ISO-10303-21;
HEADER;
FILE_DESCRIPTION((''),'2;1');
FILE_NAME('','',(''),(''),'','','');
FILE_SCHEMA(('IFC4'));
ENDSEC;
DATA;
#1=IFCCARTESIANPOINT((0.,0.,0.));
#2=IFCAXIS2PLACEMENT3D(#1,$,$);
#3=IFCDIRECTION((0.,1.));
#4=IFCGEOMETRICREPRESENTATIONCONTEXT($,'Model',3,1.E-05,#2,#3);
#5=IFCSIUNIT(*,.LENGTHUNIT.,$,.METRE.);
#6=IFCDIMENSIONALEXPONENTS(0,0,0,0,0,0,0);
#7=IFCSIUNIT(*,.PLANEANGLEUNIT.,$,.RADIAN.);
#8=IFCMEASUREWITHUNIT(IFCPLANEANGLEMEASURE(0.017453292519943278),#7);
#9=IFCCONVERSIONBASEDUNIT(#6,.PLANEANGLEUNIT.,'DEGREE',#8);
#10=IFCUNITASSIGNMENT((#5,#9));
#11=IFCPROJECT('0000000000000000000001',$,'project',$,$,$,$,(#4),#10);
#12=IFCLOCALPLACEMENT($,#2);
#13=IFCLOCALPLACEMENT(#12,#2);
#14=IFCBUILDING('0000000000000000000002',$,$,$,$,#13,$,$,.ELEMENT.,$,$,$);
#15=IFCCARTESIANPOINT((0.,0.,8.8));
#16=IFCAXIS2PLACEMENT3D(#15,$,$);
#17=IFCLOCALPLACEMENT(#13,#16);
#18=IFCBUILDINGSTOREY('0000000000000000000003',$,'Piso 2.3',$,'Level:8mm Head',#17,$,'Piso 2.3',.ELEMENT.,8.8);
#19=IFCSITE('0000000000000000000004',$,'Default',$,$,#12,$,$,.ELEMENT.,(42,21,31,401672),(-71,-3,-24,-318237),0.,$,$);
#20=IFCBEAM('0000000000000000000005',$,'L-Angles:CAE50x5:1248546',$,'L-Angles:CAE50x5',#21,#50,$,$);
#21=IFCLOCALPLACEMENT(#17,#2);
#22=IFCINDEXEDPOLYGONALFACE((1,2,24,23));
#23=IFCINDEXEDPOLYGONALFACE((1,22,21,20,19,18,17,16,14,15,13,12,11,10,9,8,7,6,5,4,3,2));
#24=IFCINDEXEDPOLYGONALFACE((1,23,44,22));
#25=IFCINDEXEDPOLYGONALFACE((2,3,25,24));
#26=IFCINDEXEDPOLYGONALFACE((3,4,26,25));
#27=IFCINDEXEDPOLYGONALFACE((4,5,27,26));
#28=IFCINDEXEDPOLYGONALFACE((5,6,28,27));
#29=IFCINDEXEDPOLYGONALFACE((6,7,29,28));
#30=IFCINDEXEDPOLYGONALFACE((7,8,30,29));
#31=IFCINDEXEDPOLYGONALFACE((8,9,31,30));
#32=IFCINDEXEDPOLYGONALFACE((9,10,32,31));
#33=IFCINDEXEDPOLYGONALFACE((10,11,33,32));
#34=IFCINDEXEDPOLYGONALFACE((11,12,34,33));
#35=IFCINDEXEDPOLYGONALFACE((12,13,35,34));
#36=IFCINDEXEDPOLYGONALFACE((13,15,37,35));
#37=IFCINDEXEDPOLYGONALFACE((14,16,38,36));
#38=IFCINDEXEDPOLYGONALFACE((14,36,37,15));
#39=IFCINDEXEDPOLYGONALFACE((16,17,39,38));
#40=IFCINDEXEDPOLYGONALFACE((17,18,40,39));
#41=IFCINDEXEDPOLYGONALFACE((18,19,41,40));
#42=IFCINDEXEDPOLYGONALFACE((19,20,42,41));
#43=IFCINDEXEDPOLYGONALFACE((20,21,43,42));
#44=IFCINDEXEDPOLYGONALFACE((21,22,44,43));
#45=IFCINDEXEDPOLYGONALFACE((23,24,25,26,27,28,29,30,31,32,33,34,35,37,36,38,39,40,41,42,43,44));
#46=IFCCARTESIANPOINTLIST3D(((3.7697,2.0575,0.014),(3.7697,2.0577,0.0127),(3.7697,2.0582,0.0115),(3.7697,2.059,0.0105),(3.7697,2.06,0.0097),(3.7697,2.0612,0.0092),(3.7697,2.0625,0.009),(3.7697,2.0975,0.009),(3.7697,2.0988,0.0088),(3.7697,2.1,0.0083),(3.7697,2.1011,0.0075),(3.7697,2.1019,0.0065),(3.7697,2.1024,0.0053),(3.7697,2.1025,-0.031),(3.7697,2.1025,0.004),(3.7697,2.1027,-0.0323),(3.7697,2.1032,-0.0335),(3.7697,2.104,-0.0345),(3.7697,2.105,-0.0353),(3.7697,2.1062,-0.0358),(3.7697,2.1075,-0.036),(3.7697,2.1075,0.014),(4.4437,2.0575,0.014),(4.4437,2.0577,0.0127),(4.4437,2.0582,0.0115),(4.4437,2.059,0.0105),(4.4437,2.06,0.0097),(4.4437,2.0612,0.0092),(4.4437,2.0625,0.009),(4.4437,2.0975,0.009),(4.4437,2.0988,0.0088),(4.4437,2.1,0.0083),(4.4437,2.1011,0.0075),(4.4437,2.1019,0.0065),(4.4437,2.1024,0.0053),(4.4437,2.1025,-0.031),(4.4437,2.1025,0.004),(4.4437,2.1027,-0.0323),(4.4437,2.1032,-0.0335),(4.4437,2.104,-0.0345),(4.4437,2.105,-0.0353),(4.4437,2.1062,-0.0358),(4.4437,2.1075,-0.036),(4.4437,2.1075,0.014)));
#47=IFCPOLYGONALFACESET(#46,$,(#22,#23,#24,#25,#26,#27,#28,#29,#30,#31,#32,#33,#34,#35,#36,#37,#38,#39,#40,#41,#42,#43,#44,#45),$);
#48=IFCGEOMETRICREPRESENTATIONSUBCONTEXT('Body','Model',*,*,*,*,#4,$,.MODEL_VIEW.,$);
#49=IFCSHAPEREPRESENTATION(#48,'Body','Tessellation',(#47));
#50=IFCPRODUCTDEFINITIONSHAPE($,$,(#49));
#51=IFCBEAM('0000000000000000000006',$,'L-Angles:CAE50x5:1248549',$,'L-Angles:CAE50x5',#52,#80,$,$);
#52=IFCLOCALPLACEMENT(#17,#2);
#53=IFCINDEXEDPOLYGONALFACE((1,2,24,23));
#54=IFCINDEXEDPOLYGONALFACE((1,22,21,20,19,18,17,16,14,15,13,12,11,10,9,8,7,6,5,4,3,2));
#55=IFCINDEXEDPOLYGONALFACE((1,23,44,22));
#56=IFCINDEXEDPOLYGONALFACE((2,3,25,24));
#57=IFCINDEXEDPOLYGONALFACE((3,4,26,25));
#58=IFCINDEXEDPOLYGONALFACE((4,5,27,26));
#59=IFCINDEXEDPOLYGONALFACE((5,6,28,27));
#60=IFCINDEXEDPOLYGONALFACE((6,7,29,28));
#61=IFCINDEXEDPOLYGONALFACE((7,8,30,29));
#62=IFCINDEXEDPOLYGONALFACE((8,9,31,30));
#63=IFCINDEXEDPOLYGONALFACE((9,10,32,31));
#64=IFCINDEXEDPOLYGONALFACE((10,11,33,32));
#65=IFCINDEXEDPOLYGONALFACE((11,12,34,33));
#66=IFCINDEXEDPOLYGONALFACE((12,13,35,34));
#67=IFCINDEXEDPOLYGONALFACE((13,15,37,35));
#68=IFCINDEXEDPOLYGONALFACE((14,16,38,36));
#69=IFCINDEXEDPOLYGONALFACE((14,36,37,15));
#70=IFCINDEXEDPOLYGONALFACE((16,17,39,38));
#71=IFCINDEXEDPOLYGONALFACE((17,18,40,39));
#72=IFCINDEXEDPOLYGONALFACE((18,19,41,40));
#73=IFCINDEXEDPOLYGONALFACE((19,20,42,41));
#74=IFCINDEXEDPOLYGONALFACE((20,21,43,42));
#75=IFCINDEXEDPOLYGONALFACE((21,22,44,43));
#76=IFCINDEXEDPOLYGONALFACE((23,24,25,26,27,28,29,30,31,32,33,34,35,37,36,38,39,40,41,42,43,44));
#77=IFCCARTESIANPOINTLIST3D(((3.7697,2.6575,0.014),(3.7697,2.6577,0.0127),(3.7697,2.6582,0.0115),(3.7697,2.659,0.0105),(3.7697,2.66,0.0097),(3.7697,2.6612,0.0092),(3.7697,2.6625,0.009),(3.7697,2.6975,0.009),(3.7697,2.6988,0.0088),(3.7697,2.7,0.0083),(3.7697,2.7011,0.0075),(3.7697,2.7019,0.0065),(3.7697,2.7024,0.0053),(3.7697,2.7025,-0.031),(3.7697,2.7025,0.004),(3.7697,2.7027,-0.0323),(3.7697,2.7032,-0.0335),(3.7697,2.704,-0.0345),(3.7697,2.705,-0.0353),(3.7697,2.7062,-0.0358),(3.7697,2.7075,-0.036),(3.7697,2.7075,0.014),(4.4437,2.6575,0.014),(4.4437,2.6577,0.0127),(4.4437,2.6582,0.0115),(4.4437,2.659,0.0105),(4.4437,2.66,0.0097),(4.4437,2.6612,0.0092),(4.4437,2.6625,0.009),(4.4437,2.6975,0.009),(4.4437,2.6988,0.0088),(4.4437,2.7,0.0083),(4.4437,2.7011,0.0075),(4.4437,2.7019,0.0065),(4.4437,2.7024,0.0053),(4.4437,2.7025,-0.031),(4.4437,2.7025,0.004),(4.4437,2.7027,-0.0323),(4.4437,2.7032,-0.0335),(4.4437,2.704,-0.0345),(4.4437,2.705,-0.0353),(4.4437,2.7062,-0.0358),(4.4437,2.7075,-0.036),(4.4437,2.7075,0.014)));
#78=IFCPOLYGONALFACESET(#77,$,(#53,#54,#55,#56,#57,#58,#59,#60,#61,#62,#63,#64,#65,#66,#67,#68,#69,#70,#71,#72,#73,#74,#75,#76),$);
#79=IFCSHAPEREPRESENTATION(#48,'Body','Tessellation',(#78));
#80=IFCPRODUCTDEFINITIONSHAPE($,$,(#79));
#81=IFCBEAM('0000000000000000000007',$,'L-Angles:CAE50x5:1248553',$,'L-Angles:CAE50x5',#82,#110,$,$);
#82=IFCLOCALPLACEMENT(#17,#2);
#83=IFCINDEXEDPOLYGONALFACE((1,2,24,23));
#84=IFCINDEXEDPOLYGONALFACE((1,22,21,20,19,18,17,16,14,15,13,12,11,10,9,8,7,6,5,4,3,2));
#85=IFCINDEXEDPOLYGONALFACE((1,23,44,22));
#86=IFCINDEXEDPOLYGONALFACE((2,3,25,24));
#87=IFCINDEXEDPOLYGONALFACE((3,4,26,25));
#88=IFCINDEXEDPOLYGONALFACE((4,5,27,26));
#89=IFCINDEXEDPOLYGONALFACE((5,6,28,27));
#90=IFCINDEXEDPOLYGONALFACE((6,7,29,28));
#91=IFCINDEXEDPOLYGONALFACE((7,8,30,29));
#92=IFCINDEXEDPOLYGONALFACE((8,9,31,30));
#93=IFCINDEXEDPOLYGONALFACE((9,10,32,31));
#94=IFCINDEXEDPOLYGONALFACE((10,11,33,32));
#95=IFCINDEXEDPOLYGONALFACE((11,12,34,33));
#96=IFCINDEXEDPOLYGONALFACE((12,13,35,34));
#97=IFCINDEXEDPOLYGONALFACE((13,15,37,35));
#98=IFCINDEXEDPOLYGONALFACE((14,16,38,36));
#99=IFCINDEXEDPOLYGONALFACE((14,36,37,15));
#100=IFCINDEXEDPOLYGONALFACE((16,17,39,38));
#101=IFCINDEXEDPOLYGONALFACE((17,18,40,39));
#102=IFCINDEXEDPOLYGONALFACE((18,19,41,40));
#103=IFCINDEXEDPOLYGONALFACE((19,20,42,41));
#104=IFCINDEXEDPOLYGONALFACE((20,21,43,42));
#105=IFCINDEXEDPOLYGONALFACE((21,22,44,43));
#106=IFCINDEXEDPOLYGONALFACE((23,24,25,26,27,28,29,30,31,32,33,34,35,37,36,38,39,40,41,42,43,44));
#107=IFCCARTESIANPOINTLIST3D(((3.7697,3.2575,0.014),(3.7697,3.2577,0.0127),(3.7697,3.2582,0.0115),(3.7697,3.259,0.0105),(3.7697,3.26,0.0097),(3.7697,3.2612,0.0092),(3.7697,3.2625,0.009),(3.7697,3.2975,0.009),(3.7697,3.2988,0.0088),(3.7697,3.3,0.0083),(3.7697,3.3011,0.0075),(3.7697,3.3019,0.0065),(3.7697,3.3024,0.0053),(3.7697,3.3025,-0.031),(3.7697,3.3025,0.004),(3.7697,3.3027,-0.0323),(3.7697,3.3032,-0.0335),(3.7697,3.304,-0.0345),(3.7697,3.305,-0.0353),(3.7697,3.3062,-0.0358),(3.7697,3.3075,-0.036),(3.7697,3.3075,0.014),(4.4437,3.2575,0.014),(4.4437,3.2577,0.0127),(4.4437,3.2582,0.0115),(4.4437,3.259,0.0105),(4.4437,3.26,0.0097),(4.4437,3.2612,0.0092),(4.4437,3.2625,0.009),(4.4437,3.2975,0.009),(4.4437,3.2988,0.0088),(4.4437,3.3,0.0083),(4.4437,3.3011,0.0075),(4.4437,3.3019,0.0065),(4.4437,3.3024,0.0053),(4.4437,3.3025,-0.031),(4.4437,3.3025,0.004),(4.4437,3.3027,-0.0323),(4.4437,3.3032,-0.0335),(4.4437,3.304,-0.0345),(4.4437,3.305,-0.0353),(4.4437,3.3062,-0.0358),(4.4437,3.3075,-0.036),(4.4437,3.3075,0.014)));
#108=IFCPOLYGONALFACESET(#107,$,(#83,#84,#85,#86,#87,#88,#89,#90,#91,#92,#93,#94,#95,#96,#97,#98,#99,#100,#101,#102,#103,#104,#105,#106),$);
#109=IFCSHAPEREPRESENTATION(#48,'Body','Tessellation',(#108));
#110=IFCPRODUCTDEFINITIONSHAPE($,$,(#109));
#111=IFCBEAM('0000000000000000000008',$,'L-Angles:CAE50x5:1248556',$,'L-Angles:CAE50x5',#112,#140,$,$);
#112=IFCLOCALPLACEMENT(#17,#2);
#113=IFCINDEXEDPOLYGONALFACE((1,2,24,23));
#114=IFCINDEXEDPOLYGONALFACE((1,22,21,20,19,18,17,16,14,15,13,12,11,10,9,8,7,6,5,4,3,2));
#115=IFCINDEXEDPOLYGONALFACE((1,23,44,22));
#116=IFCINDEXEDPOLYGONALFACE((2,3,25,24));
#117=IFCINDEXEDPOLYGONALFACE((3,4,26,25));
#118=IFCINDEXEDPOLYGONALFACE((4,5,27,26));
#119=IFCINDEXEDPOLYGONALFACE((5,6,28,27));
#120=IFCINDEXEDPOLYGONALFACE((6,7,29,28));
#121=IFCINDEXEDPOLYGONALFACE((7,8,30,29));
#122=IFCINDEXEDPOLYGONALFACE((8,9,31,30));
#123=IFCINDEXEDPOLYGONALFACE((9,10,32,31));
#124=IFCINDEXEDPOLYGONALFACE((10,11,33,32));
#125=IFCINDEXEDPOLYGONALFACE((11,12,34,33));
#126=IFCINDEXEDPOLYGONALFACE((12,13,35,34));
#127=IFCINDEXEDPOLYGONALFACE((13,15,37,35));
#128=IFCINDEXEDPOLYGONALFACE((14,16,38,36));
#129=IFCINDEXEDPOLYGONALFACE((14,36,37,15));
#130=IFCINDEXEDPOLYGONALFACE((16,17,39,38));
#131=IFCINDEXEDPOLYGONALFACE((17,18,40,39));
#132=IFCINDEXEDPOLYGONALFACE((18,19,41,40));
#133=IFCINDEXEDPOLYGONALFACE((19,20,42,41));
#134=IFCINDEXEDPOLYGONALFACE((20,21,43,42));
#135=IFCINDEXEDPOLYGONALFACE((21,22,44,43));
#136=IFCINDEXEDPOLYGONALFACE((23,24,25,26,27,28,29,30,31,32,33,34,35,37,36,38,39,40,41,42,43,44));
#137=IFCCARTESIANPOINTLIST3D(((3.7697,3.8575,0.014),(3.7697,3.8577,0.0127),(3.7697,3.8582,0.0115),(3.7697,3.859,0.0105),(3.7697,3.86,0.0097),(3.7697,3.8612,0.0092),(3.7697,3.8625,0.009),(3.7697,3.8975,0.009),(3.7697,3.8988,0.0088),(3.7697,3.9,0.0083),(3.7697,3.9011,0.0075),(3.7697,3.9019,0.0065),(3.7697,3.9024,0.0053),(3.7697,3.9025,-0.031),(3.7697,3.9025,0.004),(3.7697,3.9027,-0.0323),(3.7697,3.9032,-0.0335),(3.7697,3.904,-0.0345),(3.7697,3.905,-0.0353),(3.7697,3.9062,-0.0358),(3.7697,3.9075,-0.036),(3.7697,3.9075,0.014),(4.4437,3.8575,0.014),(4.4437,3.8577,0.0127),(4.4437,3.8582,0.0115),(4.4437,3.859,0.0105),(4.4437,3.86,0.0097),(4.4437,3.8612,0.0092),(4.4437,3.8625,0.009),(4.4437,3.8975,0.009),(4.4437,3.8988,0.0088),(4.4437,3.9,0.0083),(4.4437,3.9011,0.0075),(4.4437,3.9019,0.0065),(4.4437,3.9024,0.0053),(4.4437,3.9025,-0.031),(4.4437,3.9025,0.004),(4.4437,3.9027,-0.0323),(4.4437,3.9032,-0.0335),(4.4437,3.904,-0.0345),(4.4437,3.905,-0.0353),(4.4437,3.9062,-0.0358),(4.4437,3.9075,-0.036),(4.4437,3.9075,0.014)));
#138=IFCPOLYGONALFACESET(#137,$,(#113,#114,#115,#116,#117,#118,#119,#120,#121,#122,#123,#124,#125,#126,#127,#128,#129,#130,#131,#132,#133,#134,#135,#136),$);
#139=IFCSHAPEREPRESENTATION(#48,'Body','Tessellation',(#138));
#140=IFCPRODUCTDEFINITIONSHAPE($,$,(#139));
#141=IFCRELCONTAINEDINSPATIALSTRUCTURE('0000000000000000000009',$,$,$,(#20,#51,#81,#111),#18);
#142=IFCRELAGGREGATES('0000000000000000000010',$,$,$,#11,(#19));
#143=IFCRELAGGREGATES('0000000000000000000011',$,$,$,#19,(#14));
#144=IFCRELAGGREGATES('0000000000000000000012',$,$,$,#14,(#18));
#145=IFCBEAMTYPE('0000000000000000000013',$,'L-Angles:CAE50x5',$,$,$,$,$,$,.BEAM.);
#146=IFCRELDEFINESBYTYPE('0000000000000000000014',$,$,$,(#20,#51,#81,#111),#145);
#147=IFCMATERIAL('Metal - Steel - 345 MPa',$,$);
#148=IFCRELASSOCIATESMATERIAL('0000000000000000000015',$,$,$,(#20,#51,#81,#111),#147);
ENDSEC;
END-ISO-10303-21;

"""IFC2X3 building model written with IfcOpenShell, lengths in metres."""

from ifc_helpers import new_model, entity, si_unit, converted_unit, direction, frame, frame_2d, origin, place, context, subcontext, project, spatial, polyline, circle_curve, parameter, trimmed, segment, composite_curve, outline, extrude, material, type_object, element, save


model = new_model("IFC2X3")

# Units and contexts
model_context = context("Model", 3, precision=1e-05, world=origin(), true_north=direction((0.0, 1.0)))
body_context = subcontext(model_context, "Body", "Model", "MODEL_VIEW")
ifc_project = project(units=[si_unit("LENGTHUNIT", "METRE"), converted_unit("PLANEANGLEUNIT", "DEGREE", entity("IfcPlaneAngleMeasure", 0.017453292519943278), si_unit("PLANEANGLEUNIT", "RADIAN"), dimensions=[0, 0, 0, 0, 0, 0, 0])], contexts=[model_context])

# Site, building, storey
site_placement = place(None, origin())
site = spatial("IfcSite", under=ifc_project, at=site_placement, Name="Default", CompositionType="ELEMENT", RefLatitude=(42, 21, 31, 401672), RefLongitude=(-71, -3, -24, -318237), RefElevation=0.0)
building_placement = place(site_placement, origin())
building = spatial("IfcBuilding", under=site, at=building_placement, CompositionType="ELEMENT")
storey_placement = place(building_placement, frame((0.0, 0.0, 8.8)))
storey = spatial("IfcBuildingStorey", under=building, at=storey_placement, Name="Piso 2.3", ObjectType="Level:8mm Head", LongName="Piso 2.3", CompositionType="ELEMENT", Elevation=8.8)

# Beams
ifc_material_1 = material(Name="Metal - Steel - 345 MPa")
beam_type_1 = type_object("IfcBeamType", Name="L-Angles:CAE50x5", PredefinedType="BEAM")
beam_1_placement = place(storey_placement, frame((3.7067, 2.0935, 0.0)))
element("IfcBeam", 1, at=beam_1_placement, inside=storey, type_object=beam_type_1, material=ifc_material_1, Name="L-Angles:CAE50x5:1248546", ObjectType="L-Angles:CAE50x5", context=body_context, shape_type="SweptSolid", body=[
    extrude(outline(composite_curve([segment(polyline([(-0.0336, -0.0164), (0.0164, -0.0164)]), True, "CONTINUOUS"), segment(polyline([(0.0164, -0.0164), (0.0164, 0.0336)]), True, "CONTINUOUS"), segment(trimmed(circle_curve(frame_2d((0.0164, 0.0286), x_axis=(0.0, 1.0)), 0.005), [parameter(0.0)], [parameter(90.0)], True, "PARAMETER"), True, "CONTINUOUS"), segment(polyline([(0.0114, 0.0286), (0.0114, -0.0064)]), True, "CONTINUOUS"), segment(trimmed(circle_curve(frame_2d((0.0064, -0.0064), x_axis=(1.0, 0.0)), 0.005), [parameter(270.0)], [parameter(0.0)], True, "PARAMETER"), False, "CONTINUOUS"), segment(polyline([(0.0064, -0.0114), (-0.0286, -0.0114)]), True, "CONTINUOUS"), segment(trimmed(circle_curve(frame_2d((-0.0286, -0.0164), x_axis=(0.0, 1.0)), 0.005), [parameter(0.0)], [parameter(90.0)], True, "PARAMETER"), True, "CONTINUOUS")], self_intersect=False)), frame((0.063, -0.0024, -0.0024), z_axis=(1.0, 0.0, 0.0), x_axis=(0.0, 0.0, 1.0)), (0.0, 0.0, 1.0), 0.674),
])
beam_2_placement = place(storey_placement, frame((3.7067, 2.6935, 0.0)))
element("IfcBeam", 2, at=beam_2_placement, inside=storey, type_object=beam_type_1, material=ifc_material_1, Name="L-Angles:CAE50x5:1248549", ObjectType="L-Angles:CAE50x5", context=body_context, shape_type="SweptSolid", body=[
    extrude(outline(composite_curve([segment(polyline([(-0.0336, -0.0164), (0.0164, -0.0164)]), True, "CONTINUOUS"), segment(polyline([(0.0164, -0.0164), (0.0164, 0.0336)]), True, "CONTINUOUS"), segment(trimmed(circle_curve(frame_2d((0.0164, 0.0286), x_axis=(0.0, 1.0)), 0.005), [parameter(0.0)], [parameter(90.0)], True, "PARAMETER"), True, "CONTINUOUS"), segment(polyline([(0.0114, 0.0286), (0.0114, -0.0064)]), True, "CONTINUOUS"), segment(trimmed(circle_curve(frame_2d((0.0064, -0.0064), x_axis=(1.0, 0.0)), 0.005), [parameter(270.0)], [parameter(0.0)], True, "PARAMETER"), False, "CONTINUOUS"), segment(polyline([(0.0064, -0.0114), (-0.0286, -0.0114)]), True, "CONTINUOUS"), segment(trimmed(circle_curve(frame_2d((-0.0286, -0.0164), x_axis=(0.0, 1.0)), 0.005), [parameter(0.0)], [parameter(90.0)], True, "PARAMETER"), True, "CONTINUOUS")], self_intersect=False)), frame((0.063, -0.0024, -0.0024), z_axis=(1.0, 0.0, 0.0), x_axis=(0.0, 0.0, 1.0)), (0.0, 0.0, 1.0), 0.674),
])
beam_3_placement = place(storey_placement, frame((3.7067, 3.2935, 0.0)))
element("IfcBeam", 3, at=beam_3_placement, inside=storey, type_object=beam_type_1, material=ifc_material_1, Name="L-Angles:CAE50x5:1248553", ObjectType="L-Angles:CAE50x5", context=body_context, shape_type="SweptSolid", body=[
    extrude(outline(composite_curve([segment(polyline([(-0.0336, -0.0164), (0.0164, -0.0164)]), True, "CONTINUOUS"), segment(polyline([(0.0164, -0.0164), (0.0164, 0.0336)]), True, "CONTINUOUS"), segment(trimmed(circle_curve(frame_2d((0.0164, 0.0286), x_axis=(0.0, 1.0)), 0.005), [parameter(0.0)], [parameter(90.0)], True, "PARAMETER"), True, "CONTINUOUS"), segment(polyline([(0.0114, 0.0286), (0.0114, -0.0064)]), True, "CONTINUOUS"), segment(trimmed(circle_curve(frame_2d((0.0064, -0.0064), x_axis=(1.0, 0.0)), 0.005), [parameter(270.0)], [parameter(0.0)], True, "PARAMETER"), False, "CONTINUOUS"), segment(polyline([(0.0064, -0.0114), (-0.0286, -0.0114)]), True, "CONTINUOUS"), segment(trimmed(circle_curve(frame_2d((-0.0286, -0.0164), x_axis=(0.0, 1.0)), 0.005), [parameter(0.0)], [parameter(90.0)], True, "PARAMETER"), True, "CONTINUOUS")], self_intersect=False)), frame((0.063, -0.0024, -0.0024), z_axis=(1.0, 0.0, 0.0), x_axis=(0.0, 0.0, 1.0)), (0.0, 0.0, 1.0), 0.674),
])
beam_4_placement = place(storey_placement, frame((3.7067, 3.8935, 0.0)))
element("IfcBeam", 4, at=beam_4_placement, inside=storey, type_object=beam_type_1, material=ifc_material_1, Name="L-Angles:CAE50x5:1248556", ObjectType="L-Angles:CAE50x5", context=body_context, shape_type="SweptSolid", body=[
    extrude(outline(composite_curve([segment(polyline([(-0.0336, -0.0164), (0.0164, -0.0164)]), True, "CONTINUOUS"), segment(polyline([(0.0164, -0.0164), (0.0164, 0.0336)]), True, "CONTINUOUS"), segment(trimmed(circle_curve(frame_2d((0.0164, 0.0286), x_axis=(0.0, 1.0)), 0.005), [parameter(0.0)], [parameter(90.0)], True, "PARAMETER"), True, "CONTINUOUS"), segment(polyline([(0.0114, 0.0286), (0.0114, -0.0064)]), True, "CONTINUOUS"), segment(trimmed(circle_curve(frame_2d((0.0064, -0.0064), x_axis=(1.0, 0.0)), 0.005), [parameter(270.0)], [parameter(0.0)], True, "PARAMETER"), False, "CONTINUOUS"), segment(polyline([(0.0064, -0.0114), (-0.0286, -0.0114)]), True, "CONTINUOUS"), segment(trimmed(circle_curve(frame_2d((-0.0286, -0.0164), x_axis=(0.0, 1.0)), 0.005), [parameter(0.0)], [parameter(90.0)], True, "PARAMETER"), True, "CONTINUOUS")], self_intersect=False)), frame((0.063, -0.0024, -0.0024), z_axis=(1.0, 0.0, 0.0), x_axis=(0.0, 0.0, 1.0)), (0.0, 0.0, 1.0), 0.674),
])

save(model, "model.ifc")
